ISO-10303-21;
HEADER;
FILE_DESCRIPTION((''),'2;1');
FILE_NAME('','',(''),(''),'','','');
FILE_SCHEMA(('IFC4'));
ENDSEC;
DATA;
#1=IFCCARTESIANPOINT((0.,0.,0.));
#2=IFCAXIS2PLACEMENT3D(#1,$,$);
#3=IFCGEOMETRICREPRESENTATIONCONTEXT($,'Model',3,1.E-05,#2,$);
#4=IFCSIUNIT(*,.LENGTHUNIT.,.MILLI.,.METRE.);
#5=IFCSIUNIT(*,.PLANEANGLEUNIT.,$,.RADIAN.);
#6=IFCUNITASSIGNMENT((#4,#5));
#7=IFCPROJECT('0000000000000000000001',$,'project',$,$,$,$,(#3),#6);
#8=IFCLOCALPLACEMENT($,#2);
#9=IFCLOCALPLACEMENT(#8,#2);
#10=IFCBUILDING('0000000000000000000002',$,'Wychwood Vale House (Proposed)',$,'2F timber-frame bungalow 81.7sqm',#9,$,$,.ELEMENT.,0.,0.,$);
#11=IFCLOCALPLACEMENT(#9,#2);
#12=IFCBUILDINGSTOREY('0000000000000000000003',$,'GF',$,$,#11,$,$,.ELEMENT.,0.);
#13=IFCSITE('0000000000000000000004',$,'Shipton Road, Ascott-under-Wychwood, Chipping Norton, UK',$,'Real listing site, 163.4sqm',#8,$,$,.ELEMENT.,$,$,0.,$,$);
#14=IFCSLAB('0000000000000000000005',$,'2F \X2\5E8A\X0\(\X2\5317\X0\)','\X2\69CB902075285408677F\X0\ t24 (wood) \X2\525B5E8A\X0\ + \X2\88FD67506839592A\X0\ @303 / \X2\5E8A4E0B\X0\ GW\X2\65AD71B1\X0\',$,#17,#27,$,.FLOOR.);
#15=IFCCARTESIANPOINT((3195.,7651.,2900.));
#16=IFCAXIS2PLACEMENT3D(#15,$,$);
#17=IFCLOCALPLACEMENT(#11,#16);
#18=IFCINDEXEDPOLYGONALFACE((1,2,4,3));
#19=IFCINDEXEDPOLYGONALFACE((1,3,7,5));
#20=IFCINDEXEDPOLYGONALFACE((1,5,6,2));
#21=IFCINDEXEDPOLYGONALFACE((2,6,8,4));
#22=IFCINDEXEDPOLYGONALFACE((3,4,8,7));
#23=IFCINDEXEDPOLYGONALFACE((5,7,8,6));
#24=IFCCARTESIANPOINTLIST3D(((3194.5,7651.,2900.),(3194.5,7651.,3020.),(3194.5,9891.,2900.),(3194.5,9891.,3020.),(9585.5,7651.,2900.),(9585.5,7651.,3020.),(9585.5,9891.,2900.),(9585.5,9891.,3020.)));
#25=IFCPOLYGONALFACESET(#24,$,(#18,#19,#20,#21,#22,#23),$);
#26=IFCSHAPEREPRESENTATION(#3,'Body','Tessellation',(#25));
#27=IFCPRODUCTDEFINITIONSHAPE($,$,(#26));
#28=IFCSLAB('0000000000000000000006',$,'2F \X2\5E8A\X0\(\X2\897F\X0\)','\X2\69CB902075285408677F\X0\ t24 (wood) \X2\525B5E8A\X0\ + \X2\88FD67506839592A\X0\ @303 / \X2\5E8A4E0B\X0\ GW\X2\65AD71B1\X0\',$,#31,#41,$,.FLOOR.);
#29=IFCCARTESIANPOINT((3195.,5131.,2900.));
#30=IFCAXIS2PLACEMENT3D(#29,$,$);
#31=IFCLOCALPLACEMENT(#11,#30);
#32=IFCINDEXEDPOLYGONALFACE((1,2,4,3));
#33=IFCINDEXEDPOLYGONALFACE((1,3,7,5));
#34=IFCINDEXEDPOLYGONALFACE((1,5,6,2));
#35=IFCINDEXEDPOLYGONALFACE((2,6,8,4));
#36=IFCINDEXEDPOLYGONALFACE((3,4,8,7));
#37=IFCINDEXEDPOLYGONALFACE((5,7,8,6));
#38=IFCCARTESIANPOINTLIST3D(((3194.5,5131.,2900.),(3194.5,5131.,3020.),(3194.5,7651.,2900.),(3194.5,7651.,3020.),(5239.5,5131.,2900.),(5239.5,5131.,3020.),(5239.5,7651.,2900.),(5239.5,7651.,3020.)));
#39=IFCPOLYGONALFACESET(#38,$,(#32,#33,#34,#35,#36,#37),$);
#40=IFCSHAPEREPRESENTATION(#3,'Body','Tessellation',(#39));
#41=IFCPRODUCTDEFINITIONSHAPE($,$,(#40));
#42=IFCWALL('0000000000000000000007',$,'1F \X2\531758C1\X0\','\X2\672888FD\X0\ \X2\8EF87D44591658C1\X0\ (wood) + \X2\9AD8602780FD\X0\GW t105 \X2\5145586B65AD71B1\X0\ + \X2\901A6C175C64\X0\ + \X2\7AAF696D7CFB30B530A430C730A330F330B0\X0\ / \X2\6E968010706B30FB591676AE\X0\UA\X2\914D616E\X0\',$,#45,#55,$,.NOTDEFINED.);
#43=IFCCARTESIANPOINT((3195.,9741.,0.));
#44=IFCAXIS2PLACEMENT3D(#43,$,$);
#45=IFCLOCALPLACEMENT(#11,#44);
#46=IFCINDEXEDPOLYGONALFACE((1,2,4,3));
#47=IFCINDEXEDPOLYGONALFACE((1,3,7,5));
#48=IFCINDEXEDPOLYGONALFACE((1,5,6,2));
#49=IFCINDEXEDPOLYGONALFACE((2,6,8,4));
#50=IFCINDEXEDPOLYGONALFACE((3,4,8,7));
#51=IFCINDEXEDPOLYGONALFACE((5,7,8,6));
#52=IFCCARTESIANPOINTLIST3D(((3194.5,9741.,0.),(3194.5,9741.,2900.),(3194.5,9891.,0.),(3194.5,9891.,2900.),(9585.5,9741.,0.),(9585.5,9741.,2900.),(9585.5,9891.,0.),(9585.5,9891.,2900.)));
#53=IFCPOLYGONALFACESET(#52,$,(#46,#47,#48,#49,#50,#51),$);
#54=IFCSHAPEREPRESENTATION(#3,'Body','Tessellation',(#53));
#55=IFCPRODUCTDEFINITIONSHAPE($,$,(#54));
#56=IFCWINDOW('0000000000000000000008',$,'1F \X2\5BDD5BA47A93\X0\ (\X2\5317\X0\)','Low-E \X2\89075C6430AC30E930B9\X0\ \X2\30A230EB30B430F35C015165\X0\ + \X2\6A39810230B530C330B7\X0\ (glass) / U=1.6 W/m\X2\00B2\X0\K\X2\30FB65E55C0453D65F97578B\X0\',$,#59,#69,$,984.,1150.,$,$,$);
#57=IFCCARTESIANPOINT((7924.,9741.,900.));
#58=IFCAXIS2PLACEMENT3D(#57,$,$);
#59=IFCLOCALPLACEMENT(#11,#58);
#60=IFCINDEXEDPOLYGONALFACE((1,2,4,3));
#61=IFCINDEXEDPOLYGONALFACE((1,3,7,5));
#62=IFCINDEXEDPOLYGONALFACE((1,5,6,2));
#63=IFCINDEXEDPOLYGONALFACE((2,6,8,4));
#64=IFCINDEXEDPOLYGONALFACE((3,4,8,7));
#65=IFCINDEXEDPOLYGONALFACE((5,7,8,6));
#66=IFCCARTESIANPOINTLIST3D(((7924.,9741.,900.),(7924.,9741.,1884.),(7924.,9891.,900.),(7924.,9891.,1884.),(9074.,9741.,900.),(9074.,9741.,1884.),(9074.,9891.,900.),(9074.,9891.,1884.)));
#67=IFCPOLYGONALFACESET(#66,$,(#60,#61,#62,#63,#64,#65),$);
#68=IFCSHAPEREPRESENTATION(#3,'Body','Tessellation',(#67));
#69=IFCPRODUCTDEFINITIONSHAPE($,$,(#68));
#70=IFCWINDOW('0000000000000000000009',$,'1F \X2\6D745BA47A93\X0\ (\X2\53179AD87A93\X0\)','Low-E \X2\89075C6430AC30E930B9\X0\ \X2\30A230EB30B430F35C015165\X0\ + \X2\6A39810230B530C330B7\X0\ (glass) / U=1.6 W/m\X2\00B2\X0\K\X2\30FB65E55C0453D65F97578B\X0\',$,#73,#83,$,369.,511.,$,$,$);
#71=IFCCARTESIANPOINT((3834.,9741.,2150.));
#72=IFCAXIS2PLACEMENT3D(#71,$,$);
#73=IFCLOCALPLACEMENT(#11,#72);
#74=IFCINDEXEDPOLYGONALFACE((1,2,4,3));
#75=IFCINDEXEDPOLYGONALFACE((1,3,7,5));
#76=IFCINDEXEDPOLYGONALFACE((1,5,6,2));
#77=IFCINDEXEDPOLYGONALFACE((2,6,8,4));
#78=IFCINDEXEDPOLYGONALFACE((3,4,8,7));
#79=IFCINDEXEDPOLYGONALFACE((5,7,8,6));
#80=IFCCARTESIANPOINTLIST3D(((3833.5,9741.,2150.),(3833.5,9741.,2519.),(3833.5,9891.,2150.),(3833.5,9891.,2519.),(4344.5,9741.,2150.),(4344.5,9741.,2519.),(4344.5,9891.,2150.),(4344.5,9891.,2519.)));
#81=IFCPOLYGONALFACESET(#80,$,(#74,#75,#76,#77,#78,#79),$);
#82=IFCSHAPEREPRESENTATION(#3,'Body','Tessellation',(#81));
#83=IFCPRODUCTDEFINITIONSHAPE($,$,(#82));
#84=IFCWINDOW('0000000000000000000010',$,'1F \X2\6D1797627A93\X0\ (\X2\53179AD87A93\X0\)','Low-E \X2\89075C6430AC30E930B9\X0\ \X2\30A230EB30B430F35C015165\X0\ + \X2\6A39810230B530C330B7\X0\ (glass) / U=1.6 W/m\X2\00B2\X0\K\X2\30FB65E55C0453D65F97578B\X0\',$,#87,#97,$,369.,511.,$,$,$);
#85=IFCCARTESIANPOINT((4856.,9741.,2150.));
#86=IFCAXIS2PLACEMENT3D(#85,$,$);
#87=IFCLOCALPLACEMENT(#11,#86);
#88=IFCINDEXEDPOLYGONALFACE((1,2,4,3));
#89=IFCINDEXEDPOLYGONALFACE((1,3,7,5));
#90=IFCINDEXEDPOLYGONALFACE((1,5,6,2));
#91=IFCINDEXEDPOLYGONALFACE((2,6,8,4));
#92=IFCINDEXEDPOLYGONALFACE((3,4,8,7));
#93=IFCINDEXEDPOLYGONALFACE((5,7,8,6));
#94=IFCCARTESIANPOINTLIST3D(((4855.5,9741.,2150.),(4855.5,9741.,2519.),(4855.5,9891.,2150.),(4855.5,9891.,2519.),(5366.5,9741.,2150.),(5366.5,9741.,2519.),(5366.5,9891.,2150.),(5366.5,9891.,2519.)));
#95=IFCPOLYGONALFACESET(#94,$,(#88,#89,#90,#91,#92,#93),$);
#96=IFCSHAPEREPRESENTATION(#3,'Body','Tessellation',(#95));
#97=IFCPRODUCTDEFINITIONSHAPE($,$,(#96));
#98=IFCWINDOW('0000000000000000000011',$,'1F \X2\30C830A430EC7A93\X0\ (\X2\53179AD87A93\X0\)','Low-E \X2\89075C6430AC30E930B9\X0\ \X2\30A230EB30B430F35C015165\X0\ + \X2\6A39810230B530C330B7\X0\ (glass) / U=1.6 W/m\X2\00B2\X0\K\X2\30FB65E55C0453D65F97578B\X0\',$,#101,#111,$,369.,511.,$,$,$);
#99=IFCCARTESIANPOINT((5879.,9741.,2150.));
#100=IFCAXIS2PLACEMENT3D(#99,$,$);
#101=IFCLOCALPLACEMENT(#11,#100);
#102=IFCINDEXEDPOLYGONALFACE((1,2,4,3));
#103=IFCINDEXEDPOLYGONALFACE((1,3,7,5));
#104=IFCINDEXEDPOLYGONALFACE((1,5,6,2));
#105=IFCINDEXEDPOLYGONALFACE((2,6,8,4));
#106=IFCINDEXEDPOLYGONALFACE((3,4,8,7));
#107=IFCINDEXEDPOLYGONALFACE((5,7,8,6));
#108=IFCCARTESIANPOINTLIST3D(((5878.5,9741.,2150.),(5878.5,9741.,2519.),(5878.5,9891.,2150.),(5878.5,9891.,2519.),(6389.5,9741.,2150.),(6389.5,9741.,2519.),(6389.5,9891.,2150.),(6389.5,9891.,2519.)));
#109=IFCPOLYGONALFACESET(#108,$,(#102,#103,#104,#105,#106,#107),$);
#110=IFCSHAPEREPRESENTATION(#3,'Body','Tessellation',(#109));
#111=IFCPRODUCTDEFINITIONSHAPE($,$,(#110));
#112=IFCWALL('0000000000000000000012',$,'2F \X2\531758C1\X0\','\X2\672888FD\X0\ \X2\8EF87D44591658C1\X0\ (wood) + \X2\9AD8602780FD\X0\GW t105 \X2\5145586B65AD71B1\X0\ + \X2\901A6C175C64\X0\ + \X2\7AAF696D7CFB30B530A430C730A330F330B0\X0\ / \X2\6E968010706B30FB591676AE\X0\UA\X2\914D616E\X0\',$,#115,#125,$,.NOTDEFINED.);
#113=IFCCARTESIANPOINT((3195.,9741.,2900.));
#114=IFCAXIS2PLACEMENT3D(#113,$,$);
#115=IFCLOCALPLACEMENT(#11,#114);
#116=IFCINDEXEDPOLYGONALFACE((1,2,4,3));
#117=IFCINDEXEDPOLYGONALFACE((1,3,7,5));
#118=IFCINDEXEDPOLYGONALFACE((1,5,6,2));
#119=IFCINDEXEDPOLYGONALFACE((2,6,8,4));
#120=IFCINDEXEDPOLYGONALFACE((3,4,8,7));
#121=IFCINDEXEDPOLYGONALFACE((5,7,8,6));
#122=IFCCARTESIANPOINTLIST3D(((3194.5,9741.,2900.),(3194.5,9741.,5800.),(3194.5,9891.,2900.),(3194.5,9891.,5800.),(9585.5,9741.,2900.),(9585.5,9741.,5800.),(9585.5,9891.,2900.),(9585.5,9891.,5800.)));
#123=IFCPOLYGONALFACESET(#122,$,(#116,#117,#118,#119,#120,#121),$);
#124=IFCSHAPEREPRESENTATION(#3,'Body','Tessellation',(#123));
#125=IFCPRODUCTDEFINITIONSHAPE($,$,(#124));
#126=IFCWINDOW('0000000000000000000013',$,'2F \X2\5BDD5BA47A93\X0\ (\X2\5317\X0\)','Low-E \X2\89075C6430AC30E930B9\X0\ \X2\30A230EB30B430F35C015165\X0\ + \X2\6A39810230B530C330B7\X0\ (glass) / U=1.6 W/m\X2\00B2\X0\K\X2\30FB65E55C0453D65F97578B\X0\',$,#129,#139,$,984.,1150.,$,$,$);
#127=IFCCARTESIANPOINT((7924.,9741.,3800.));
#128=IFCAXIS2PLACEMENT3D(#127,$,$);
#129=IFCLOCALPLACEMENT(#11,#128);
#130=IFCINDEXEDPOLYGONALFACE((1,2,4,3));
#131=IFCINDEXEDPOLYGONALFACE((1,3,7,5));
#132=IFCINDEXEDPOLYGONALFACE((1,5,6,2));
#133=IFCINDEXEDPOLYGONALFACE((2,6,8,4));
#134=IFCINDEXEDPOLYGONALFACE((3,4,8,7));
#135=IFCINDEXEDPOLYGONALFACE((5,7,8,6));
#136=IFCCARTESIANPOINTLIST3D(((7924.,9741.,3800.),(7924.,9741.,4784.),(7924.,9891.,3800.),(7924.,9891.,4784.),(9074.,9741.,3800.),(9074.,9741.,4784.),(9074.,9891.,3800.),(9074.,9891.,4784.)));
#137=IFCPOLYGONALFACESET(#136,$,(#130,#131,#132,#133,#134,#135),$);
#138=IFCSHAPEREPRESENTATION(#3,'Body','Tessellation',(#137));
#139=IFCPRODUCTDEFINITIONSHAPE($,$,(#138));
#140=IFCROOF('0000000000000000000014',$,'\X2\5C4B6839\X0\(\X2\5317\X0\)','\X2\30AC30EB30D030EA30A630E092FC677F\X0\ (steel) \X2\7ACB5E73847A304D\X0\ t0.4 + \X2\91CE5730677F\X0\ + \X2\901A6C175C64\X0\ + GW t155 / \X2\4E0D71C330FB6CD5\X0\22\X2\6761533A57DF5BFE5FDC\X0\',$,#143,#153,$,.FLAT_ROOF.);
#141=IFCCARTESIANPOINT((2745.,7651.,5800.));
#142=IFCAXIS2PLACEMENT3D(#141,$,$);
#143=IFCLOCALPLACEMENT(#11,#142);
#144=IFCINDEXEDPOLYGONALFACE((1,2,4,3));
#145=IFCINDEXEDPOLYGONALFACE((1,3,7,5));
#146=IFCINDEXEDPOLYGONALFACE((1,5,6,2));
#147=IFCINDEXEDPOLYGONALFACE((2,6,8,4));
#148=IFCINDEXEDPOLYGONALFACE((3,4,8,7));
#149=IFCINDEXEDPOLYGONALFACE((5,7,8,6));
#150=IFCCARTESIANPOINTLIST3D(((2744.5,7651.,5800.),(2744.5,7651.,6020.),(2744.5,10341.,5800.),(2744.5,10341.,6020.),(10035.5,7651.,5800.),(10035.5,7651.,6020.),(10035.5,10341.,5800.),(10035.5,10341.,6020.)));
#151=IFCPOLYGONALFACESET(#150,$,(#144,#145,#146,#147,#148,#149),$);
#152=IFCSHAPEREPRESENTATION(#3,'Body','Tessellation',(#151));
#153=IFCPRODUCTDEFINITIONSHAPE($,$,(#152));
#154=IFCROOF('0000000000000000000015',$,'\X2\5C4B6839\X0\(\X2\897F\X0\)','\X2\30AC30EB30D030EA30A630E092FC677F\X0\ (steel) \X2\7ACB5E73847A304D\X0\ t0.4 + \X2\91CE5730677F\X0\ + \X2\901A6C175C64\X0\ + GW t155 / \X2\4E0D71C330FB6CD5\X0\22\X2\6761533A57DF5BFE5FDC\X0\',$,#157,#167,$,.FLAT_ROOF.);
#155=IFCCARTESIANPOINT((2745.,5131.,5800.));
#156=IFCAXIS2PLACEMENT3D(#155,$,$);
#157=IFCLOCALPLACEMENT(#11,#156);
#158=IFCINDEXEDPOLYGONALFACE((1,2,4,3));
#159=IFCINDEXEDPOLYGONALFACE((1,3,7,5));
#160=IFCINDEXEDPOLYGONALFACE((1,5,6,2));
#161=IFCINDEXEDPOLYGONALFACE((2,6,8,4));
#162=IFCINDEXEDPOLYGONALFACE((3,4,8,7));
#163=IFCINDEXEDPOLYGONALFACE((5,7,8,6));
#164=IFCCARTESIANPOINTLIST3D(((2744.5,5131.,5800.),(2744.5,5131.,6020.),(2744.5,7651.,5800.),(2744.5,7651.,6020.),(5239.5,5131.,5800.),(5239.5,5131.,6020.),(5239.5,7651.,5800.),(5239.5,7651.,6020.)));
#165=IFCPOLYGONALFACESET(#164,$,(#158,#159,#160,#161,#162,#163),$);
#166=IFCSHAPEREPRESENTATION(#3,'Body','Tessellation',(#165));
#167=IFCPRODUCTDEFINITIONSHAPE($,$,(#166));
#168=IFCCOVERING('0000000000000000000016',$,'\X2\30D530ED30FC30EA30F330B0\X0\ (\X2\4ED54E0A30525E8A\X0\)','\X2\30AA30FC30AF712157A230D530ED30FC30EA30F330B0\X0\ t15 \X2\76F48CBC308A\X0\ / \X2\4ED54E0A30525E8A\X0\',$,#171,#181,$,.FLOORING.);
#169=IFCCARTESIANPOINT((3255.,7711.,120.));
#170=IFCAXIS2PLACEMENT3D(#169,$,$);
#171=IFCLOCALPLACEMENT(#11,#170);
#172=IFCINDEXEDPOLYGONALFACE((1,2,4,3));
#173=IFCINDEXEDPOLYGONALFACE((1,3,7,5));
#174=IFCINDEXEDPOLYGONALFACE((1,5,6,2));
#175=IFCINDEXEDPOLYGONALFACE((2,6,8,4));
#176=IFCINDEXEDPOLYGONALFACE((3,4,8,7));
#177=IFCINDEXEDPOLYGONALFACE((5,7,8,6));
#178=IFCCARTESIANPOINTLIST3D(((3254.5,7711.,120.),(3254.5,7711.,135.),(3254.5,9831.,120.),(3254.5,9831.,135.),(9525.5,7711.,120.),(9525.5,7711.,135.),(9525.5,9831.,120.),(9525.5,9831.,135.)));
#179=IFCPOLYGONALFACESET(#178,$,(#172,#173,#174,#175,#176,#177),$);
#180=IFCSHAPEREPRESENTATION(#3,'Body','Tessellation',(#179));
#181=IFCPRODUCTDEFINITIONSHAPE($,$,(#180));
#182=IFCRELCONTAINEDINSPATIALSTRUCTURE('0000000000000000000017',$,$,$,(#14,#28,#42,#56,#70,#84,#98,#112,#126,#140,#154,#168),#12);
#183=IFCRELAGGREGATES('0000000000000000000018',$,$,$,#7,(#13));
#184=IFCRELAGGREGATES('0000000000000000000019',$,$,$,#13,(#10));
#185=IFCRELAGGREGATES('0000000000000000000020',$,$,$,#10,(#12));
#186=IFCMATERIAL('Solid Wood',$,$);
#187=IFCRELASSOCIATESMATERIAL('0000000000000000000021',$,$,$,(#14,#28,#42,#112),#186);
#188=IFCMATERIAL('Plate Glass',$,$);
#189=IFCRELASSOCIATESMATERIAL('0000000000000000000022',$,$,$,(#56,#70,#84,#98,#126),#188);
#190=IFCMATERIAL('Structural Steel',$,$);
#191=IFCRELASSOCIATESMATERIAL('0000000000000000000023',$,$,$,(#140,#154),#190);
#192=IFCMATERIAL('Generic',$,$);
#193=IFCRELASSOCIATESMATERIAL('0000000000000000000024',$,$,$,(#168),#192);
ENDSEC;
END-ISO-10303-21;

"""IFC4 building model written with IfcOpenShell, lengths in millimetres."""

from ifc_helpers import new_model, si_unit, frame, frame_2d, origin, place, context, project, spatial, rectangle, extrude, material, element, fill, save


model = new_model("IFC4")

# Units and contexts
model_context = context("Model", 3, precision=1e-05, world=origin())
ifc_project = project(units=[si_unit("LENGTHUNIT", "METRE", prefix="MILLI"), si_unit("PLANEANGLEUNIT", "RADIAN")], contexts=[model_context])

# Site, building, storey
site_placement = place(None, origin())
site = spatial("IfcSite", under=ifc_project, at=site_placement, Name="Shipton Road, Ascott-under-Wychwood, Chipping Norton, UK", ObjectType="Real listing site, 163.4sqm", CompositionType="ELEMENT", RefElevation=0.0)
building_placement = place(site_placement, origin())
building = spatial("IfcBuilding", under=site, at=building_placement, Name="Wychwood Vale House (Proposed)", ObjectType="2F timber-frame bungalow 81.7sqm", CompositionType="ELEMENT", ElevationOfRefHeight=0.0, ElevationOfTerrain=0.0)
storey_placement = place(building_placement, origin())
storey = spatial("IfcBuildingStorey", under=building, at=storey_placement, Name="GF", CompositionType="ELEMENT", Elevation=0.0)

# Slabs
ifc_material_1 = material(Name="Solid Wood")
slab_1_placement = place(storey_placement, frame((3195.0, 7651.0, 2900.0)))
element("IfcSlab", 1, at=slab_1_placement, inside=storey, material=ifc_material_1, Name="2F 床(北)", Description="構造用合板 t24 (wood) 剛床 + 製材根太 @303 / 床下 GW断熱", PredefinedType="FLOOR", context=model_context, shape_type="SweptSolid", body=[
    extrude(rectangle(XDim=6391.0, YDim=2240.0, at=frame_2d((3195.0, 1120.0))), frame((3195.0, 7651.0, 2900.0)), (0.0, 0.0, 1.0), 120.0),
])
slab_2_placement = place(storey_placement, frame((3195.0, 5131.0, 2900.0)))
element("IfcSlab", 2, at=slab_2_placement, inside=storey, material=ifc_material_1, Name="2F 床(西)", Description="構造用合板 t24 (wood) 剛床 + 製材根太 @303 / 床下 GW断熱", PredefinedType="FLOOR", context=model_context, shape_type="SweptSolid", body=[
    extrude(rectangle(XDim=2045.0, YDim=2520.0, at=frame_2d((1022.0, 1260.0))), frame((3195.0, 5131.0, 2900.0)), (0.0, 0.0, 1.0), 120.0),
])

# Wall, openings, windows
wall_1_placement = place(storey_placement, frame((3195.0, 9741.0, 0.0)))
wall_1 = element("IfcWall", 3, at=wall_1_placement, inside=storey, material=ifc_material_1, Name="1F 北壁", Description="木製 軸組外壁 (wood) + 高性能GW t105 充填断熱 + 通気層 + 窯業系サイディング / 準耐火・外皮UA配慮", PredefinedType="NOTDEFINED", context=model_context, shape_type="SweptSolid", body=[
    extrude(rectangle(XDim=6391.0, YDim=150.0, at=frame_2d((3195.0, 75.0))), frame((3195.0, 9741.0, 0.0)), (0.0, 0.0, 1.0), 2900.0),
])
opening_1_placement = place(storey_placement, frame((7924.0, 9741.0, 900.0)))
opening_1 = element("IfcOpeningElement", 4, at=opening_1_placement, cuts=wall_1, PredefinedType="NOTDEFINED", context=model_context, shape_type="SweptSolid", body=[
    extrude(rectangle(XDim=1150.0, YDim=150.0, at=frame_2d((575.0, 75.0))), frame((7924.0, 9741.0, 900.0)), (0.0, 0.0, 1.0), 984.0),
])
opening_2_placement = place(storey_placement, frame((3834.0, 9741.0, 2150.0)))
opening_2 = element("IfcOpeningElement", 5, at=opening_2_placement, cuts=wall_1, PredefinedType="NOTDEFINED", context=model_context, shape_type="SweptSolid", body=[
    extrude(rectangle(XDim=511.0, YDim=150.0, at=frame_2d((255.0, 75.0))), frame((3834.0, 9741.0, 2150.0)), (0.0, 0.0, 1.0), 369.0),
])
opening_3_placement = place(storey_placement, frame((4856.0, 9741.0, 2150.0)))
opening_3 = element("IfcOpeningElement", 6, at=opening_3_placement, cuts=wall_1, PredefinedType="NOTDEFINED", context=model_context, shape_type="SweptSolid", body=[
    extrude(rectangle(XDim=511.0, YDim=150.0, at=frame_2d((255.0, 75.0))), frame((4856.0, 9741.0, 2150.0)), (0.0, 0.0, 1.0), 369.0),
])
opening_4_placement = place(storey_placement, frame((5879.0, 9741.0, 2150.0)))
opening_4 = element("IfcOpeningElement", 7, at=opening_4_placement, cuts=wall_1, PredefinedType="NOTDEFINED", context=model_context, shape_type="SweptSolid", body=[
    extrude(rectangle(XDim=511.0, YDim=150.0, at=frame_2d((255.0, 75.0))), frame((5879.0, 9741.0, 2150.0)), (0.0, 0.0, 1.0), 369.0),
])
ifc_material_2 = material(Name="Plate Glass")
window_1_placement = place(storey_placement, frame((7924.0, 9741.0, 900.0)))
window_1 = element("IfcWindow", 8, at=window_1_placement, inside=storey, material=ifc_material_2, Name="1F 寝室窓 (北)", Description="Low-E 複層ガラス アルゴン封入 + 樹脂サッシ (glass) / U=1.6 W/m²K・日射取得型", OverallHeight=984.0, OverallWidth=1150.0, context=model_context, shape_type="SweptSolid", body=[
    extrude(rectangle(XDim=1150.0, YDim=150.0, at=frame_2d((575.0, 75.0))), frame((7924.0, 9741.0, 900.0)), (0.0, 0.0, 1.0), 984.0),
])
fill(opening_1, window_1)
window_2_placement = place(storey_placement, frame((3834.0, 9741.0, 2150.0)))
window_2 = element("IfcWindow", 9, at=window_2_placement, inside=storey, material=ifc_material_2, Name="1F 浴室窓 (北高窓)", Description="Low-E 複層ガラス アルゴン封入 + 樹脂サッシ (glass) / U=1.6 W/m²K・日射取得型", OverallHeight=369.0, OverallWidth=511.0, context=model_context, shape_type="SweptSolid", body=[
    extrude(rectangle(XDim=511.0, YDim=150.0, at=frame_2d((255.0, 75.0))), frame((3834.0, 9741.0, 2150.0)), (0.0, 0.0, 1.0), 369.0),
])
fill(opening_2, window_2)
window_3_placement = place(storey_placement, frame((4856.0, 9741.0, 2150.0)))
window_3 = element("IfcWindow", 10, at=window_3_placement, inside=storey, material=ifc_material_2, Name="1F 洗面窓 (北高窓)", Description="Low-E 複層ガラス アルゴン封入 + 樹脂サッシ (glass) / U=1.6 W/m²K・日射取得型", OverallHeight=369.0, OverallWidth=511.0, context=model_context, shape_type="SweptSolid", body=[
    extrude(rectangle(XDim=511.0, YDim=150.0, at=frame_2d((255.0, 75.0))), frame((4856.0, 9741.0, 2150.0)), (0.0, 0.0, 1.0), 369.0),
])
fill(opening_3, window_3)
window_4_placement = place(storey_placement, frame((5879.0, 9741.0, 2150.0)))
window_4 = element("IfcWindow", 11, at=window_4_placement, inside=storey, material=ifc_material_2, Name="1F トイレ窓 (北高窓)", Description="Low-E 複層ガラス アルゴン封入 + 樹脂サッシ (glass) / U=1.6 W/m²K・日射取得型", OverallHeight=369.0, OverallWidth=511.0, context=model_context, shape_type="SweptSolid", body=[
    extrude(rectangle(XDim=511.0, YDim=150.0, at=frame_2d((255.0, 75.0))), frame((5879.0, 9741.0, 2150.0)), (0.0, 0.0, 1.0), 369.0),
])
fill(opening_4, window_4)

# Wall, opening, window
wall_2_placement = place(storey_placement, frame((3195.0, 9741.0, 2900.0)))
wall_2 = element("IfcWall", 12, at=wall_2_placement, inside=storey, material=ifc_material_1, Name="2F 北壁", Description="木製 軸組外壁 (wood) + 高性能GW t105 充填断熱 + 通気層 + 窯業系サイディング / 準耐火・外皮UA配慮", PredefinedType="NOTDEFINED", context=model_context, shape_type="SweptSolid", body=[
    extrude(rectangle(XDim=6391.0, YDim=150.0, at=frame_2d((3195.0, 75.0))), frame((3195.0, 9741.0, 2900.0)), (0.0, 0.0, 1.0), 2900.0),
])
opening_5_placement = place(storey_placement, frame((7924.0, 9741.0, 3800.0)))
opening_5 = element("IfcOpeningElement", 13, at=opening_5_placement, cuts=wall_2, PredefinedType="NOTDEFINED", context=model_context, shape_type="SweptSolid", body=[
    extrude(rectangle(XDim=1150.0, YDim=150.0, at=frame_2d((575.0, 75.0))), frame((7924.0, 9741.0, 3800.0)), (0.0, 0.0, 1.0), 984.0),
])
window_5_placement = place(storey_placement, frame((7924.0, 9741.0, 3800.0)))
window_5 = element("IfcWindow", 14, at=window_5_placement, inside=storey, material=ifc_material_2, Name="2F 寝室窓 (北)", Description="Low-E 複層ガラス アルゴン封入 + 樹脂サッシ (glass) / U=1.6 W/m²K・日射取得型", OverallHeight=984.0, OverallWidth=1150.0, context=model_context, shape_type="SweptSolid", body=[
    extrude(rectangle(XDim=1150.0, YDim=150.0, at=frame_2d((575.0, 75.0))), frame((7924.0, 9741.0, 3800.0)), (0.0, 0.0, 1.0), 984.0),
])
fill(opening_5, window_5)

# Roofs
ifc_material_3 = material(Name="Structural Steel")
for number, where, name in (
    (15, (2745.0, 7651.0, 5800.0), "屋根(北)"),
):
    element("IfcRoof", number, at=place(storey_placement, frame(where)), inside=storey, material=ifc_material_3, Name=name, Description="ガルバリウム鋼板 (steel) 立平葺き t0.4 + 野地板 + 通気層 + GW t155 / 不燃・法22条区域対応", PredefinedType="FLAT_ROOF", context=model_context, shape_type="SweptSolid", body=[
        extrude(rectangle(XDim=7291.0, YDim=2690.0, at=frame_2d((3645.0, 1345.0))), frame((2745.0, 7651.0, 5800.0)), (0.0, 0.0, 1.0), 220.0),
    ])
roof_placement = place(storey_placement, frame((2745.0, 5131.0, 5800.0)))
element("IfcRoof", 16, at=roof_placement, inside=storey, material=ifc_material_3, Name="屋根(西)", Description="ガルバリウム鋼板 (steel) 立平葺き t0.4 + 野地板 + 通気層 + GW t155 / 不燃・法22条区域対応", PredefinedType="FLAT_ROOF", context=model_context, shape_type="SweptSolid", body=[
    extrude(rectangle(XDim=2495.0, YDim=2520.0, at=frame_2d((1247.0, 1260.0))), frame((2745.0, 5131.0, 5800.0)), (0.0, 0.0, 1.0), 220.0),
])

# Covering
ifc_material_4 = material(Name="Generic")
covering_1_placement = place(storey_placement, frame((3255.0, 7711.0, 120.0)))
element("IfcCovering", 17, at=covering_1_placement, inside=storey, material=ifc_material_4, Name="フローリング (仕上げ床)", Description="オーク無垢フローリング t15 直貼り / 仕上げ床", PredefinedType="FLOORING", context=model_context, shape_type="SweptSolid", body=[
    extrude(rectangle(XDim=6271.0, YDim=2120.0, at=frame_2d((3135.0, 1060.0))), frame((3255.0, 7711.0, 120.0)), (0.0, 0.0, 1.0), 15.0),
])

save(model, "model.ifc")
